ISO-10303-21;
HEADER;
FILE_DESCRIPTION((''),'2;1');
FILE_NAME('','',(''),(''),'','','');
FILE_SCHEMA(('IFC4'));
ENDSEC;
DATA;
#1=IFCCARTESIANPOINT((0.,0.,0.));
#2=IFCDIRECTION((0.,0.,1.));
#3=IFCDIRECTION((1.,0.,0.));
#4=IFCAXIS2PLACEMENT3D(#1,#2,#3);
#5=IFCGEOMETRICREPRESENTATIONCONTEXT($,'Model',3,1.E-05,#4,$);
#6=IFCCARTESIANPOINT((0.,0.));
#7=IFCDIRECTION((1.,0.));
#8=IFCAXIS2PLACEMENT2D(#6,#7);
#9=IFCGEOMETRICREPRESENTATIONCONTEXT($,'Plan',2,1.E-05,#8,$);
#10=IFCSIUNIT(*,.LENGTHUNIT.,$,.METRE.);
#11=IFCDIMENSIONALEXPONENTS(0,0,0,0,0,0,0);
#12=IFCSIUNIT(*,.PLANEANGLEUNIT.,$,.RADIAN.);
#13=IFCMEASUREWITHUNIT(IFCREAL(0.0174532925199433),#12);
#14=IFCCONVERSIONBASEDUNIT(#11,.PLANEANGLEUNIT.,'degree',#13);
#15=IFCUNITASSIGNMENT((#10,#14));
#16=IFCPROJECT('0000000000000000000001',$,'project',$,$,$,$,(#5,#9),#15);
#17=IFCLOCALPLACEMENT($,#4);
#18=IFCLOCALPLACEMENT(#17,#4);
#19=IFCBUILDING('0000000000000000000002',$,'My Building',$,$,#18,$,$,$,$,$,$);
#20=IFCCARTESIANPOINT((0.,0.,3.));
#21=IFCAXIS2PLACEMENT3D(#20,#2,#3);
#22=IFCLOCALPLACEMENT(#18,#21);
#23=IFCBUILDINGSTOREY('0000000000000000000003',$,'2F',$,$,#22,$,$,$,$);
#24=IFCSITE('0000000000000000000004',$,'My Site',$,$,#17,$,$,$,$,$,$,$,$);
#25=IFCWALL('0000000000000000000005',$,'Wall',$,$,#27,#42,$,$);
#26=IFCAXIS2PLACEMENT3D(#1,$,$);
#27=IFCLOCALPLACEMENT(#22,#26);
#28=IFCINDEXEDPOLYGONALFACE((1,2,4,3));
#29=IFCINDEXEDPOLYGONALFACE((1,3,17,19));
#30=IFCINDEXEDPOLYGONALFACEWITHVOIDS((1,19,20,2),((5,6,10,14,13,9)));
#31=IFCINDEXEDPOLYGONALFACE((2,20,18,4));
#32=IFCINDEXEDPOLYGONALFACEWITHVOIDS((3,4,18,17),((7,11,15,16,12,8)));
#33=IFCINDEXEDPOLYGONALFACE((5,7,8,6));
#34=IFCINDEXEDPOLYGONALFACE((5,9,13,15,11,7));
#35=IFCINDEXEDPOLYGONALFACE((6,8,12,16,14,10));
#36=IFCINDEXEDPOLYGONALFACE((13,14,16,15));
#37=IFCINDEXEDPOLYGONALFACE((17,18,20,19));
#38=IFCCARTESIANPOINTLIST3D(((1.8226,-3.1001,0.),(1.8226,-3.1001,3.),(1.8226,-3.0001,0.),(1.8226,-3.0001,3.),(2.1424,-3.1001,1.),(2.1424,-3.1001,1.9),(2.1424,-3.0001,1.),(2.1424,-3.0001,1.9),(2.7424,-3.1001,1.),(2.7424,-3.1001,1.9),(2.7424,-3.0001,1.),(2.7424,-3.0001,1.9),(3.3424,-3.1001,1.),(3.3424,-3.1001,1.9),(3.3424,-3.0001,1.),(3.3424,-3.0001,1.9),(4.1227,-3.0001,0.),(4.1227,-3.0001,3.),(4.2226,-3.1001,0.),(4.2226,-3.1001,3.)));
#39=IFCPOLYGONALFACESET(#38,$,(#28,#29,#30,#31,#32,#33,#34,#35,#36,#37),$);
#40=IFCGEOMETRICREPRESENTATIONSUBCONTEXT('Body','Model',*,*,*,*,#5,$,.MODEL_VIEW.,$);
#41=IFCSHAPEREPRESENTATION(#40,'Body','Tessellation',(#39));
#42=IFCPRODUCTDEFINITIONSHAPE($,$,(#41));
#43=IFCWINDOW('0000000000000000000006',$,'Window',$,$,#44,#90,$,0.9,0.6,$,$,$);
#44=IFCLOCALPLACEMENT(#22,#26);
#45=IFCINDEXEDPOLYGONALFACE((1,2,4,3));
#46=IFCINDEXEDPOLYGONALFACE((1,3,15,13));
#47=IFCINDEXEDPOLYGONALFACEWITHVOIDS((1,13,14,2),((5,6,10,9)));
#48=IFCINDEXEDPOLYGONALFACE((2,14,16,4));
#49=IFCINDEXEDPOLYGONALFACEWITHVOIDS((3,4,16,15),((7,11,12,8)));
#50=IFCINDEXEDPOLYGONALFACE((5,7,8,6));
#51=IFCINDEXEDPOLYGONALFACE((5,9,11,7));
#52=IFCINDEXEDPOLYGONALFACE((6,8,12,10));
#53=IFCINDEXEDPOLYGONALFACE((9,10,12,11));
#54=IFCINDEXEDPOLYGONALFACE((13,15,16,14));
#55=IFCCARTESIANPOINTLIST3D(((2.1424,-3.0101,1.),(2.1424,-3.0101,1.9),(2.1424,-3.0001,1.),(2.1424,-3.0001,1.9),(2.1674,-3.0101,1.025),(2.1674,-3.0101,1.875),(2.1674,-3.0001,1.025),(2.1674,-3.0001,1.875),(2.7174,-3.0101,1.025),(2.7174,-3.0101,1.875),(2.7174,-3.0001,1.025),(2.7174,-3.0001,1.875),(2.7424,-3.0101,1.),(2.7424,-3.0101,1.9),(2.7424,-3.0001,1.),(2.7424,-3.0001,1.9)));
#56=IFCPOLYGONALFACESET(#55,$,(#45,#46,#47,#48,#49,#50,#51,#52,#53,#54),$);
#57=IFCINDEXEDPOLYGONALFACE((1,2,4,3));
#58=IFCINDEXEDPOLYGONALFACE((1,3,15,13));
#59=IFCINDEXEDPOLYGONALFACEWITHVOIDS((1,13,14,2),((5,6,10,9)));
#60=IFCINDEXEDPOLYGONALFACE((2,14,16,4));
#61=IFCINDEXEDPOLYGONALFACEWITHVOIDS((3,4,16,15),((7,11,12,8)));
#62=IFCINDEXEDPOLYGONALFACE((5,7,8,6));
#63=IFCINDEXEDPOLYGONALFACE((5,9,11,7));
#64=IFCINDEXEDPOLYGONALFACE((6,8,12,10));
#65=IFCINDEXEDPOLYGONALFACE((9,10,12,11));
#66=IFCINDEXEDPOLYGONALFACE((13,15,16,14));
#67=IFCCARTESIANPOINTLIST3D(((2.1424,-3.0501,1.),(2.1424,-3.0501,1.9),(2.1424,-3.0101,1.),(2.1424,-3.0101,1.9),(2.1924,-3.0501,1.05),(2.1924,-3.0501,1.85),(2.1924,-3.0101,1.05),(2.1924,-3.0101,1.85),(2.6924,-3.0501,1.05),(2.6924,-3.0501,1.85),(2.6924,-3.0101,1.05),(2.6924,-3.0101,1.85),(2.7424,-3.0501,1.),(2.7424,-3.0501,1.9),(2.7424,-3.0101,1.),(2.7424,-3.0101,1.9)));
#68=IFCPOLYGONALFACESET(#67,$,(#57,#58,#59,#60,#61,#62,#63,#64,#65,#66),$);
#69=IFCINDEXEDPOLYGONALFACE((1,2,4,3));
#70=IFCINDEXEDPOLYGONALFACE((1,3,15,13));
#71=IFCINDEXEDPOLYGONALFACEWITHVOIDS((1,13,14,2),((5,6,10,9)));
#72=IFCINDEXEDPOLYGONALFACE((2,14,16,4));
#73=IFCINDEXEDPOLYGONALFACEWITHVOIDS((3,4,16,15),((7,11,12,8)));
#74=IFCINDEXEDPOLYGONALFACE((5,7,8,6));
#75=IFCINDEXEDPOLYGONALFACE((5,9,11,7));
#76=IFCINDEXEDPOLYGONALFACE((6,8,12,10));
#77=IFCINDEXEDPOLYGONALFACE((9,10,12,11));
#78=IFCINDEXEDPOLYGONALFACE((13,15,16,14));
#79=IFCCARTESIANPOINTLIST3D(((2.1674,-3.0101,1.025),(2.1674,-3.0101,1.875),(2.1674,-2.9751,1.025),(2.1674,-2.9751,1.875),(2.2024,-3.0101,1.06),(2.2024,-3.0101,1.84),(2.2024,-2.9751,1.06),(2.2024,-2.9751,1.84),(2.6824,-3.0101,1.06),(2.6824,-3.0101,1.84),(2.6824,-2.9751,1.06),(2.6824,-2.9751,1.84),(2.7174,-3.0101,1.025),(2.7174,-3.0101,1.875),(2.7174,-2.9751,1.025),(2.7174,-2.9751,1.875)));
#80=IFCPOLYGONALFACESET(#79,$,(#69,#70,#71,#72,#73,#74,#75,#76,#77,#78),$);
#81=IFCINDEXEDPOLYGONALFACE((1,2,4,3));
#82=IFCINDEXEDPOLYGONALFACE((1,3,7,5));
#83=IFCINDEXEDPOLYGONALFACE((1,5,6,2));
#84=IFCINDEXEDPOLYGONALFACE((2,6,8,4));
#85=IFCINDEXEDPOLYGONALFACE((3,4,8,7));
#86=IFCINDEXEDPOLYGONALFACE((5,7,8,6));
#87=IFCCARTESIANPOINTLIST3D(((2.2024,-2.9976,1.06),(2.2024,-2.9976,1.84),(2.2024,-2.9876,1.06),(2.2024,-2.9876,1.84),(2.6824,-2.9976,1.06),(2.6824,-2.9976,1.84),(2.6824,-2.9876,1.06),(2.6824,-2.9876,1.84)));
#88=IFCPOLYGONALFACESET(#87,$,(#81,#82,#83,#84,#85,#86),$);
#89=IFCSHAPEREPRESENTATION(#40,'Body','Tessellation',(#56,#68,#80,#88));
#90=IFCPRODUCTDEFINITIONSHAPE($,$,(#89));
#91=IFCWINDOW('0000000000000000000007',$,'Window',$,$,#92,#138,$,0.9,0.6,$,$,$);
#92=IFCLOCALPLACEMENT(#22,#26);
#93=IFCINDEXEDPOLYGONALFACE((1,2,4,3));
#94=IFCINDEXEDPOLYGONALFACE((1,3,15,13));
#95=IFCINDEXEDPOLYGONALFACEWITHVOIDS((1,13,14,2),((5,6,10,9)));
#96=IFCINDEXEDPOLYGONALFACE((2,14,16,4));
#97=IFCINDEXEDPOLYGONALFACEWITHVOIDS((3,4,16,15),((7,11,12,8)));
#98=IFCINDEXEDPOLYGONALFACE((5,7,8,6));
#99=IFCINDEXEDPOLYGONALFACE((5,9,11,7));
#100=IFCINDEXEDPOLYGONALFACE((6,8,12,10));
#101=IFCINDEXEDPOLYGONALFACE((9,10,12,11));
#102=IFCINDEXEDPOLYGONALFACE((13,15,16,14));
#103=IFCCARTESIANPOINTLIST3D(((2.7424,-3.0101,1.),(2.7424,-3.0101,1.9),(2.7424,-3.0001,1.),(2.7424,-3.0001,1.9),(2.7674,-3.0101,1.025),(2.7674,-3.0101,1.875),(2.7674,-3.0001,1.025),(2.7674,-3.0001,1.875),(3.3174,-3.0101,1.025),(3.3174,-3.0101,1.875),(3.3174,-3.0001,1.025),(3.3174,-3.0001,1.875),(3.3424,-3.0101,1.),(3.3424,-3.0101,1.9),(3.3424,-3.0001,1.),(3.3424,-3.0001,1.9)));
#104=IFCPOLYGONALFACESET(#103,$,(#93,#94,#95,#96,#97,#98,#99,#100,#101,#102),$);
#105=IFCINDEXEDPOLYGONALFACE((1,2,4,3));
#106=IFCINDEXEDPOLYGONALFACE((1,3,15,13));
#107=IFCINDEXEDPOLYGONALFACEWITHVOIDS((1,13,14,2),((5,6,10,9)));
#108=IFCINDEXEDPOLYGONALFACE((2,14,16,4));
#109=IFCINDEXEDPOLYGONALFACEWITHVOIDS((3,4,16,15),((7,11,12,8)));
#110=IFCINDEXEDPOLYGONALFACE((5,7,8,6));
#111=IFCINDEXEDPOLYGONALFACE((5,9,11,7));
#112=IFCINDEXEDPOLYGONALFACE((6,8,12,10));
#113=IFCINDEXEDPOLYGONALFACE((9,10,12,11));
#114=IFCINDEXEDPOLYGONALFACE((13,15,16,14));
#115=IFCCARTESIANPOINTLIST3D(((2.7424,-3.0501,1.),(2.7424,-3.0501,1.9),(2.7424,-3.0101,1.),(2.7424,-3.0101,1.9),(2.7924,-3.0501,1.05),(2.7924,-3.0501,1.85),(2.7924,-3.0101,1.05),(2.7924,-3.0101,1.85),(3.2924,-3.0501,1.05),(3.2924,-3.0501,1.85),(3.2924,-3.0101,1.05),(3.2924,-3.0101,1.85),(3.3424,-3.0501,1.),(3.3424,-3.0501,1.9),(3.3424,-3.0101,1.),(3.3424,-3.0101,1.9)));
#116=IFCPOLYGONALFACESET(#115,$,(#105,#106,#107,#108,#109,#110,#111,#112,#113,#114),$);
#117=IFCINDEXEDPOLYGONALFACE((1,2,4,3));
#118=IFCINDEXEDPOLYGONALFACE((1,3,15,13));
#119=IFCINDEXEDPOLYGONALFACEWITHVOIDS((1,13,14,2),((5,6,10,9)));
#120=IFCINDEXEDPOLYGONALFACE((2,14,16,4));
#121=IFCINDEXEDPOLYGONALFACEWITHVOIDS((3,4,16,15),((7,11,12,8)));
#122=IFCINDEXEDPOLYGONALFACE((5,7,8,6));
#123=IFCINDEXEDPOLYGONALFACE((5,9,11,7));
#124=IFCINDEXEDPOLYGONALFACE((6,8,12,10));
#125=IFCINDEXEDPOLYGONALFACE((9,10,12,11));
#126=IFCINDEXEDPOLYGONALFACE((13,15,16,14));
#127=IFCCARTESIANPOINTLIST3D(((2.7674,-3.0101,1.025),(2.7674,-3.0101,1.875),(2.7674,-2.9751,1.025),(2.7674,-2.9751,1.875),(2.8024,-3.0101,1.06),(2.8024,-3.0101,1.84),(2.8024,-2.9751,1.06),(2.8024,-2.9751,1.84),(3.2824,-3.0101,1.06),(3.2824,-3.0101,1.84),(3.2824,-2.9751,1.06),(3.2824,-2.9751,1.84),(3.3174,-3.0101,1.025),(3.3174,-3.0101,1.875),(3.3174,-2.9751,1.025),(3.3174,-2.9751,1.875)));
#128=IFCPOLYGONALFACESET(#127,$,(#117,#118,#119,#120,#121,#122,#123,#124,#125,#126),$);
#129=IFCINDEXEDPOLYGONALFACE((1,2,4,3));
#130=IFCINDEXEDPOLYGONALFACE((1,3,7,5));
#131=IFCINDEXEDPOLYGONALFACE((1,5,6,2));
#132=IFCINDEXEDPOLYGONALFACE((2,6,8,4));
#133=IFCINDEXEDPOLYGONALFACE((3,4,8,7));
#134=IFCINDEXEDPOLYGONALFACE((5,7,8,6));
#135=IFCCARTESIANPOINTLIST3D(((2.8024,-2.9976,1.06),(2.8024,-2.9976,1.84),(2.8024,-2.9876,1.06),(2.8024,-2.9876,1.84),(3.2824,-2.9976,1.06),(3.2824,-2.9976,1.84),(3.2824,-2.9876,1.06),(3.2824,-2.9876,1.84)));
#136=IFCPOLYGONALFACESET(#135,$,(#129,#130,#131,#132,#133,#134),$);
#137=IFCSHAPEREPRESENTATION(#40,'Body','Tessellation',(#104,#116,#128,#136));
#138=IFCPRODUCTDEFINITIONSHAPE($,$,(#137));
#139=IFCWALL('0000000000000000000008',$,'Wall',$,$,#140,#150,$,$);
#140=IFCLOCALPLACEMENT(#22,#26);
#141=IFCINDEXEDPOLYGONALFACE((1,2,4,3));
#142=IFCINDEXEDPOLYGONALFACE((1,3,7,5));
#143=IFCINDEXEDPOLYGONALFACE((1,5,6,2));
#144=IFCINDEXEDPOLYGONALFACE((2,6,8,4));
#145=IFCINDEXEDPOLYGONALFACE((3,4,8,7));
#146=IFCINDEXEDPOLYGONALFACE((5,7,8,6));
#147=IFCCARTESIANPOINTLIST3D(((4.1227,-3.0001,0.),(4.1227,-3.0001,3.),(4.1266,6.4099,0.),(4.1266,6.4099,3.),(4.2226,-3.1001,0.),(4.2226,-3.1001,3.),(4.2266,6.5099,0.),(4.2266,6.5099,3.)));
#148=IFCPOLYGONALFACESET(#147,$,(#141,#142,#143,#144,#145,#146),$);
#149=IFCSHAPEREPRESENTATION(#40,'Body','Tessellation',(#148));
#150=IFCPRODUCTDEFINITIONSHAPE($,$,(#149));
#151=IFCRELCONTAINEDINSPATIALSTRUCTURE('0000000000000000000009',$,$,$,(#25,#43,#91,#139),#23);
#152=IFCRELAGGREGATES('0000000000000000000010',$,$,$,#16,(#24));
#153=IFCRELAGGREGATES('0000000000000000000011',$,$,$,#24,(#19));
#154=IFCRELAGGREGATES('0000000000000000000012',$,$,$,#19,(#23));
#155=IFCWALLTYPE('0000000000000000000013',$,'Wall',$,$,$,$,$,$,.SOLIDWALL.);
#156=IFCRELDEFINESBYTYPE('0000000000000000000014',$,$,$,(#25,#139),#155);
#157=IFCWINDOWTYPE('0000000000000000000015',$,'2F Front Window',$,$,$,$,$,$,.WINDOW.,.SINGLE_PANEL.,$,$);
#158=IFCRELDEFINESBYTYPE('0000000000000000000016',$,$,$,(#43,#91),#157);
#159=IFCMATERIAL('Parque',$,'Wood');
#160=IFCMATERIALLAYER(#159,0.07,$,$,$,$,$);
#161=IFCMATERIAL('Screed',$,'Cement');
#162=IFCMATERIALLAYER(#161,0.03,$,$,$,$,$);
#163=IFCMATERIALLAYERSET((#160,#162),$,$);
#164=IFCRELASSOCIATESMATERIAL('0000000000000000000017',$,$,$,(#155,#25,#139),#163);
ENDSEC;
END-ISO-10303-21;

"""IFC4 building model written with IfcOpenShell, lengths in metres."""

from ifc_helpers import new_model, entity, si_unit, converted_unit, frame, origin_with_axes, origin_2d_with_axis, place, context, subcontext, project, spatial, line, indexed_curve, outline, extrude, shape, source, transform, mapped, material, layer, layer_set, layer_usage, type_object, type_shapes, element, fill, save


model = new_model("IFC4")

# Units and contexts
model_context = context("Model", 3, precision=1e-05, world=origin_with_axes())
plan_context = context("Plan", 2, precision=1e-05, world=origin_2d_with_axis())
body_context_1 = subcontext(model_context, "Body", "Model", "MODEL_VIEW")
body_context_2 = subcontext(plan_context, "Body", "Plan", "PLAN_VIEW")
ifc_project = project(units=[si_unit("LENGTHUNIT", "METRE"), converted_unit("PLANEANGLEUNIT", "degree", entity("IfcReal", 0.0174532925199433), si_unit("PLANEANGLEUNIT", "RADIAN"), dimensions=[0, 0, 0, 0, 0, 0, 0])], contexts=[model_context, plan_context])

# Site, building, storey
site_placement = place(None, origin_with_axes())
site = spatial("IfcSite", under=ifc_project, at=site_placement, Name="My Site")
building_placement = place(site_placement, origin_with_axes())
building = spatial("IfcBuilding", under=site, at=building_placement, Name="My Building")
storey_placement = place(building_placement, frame((0.0, 0.0, 3.0), z_axis=(0.0, 0.0, 1.0), x_axis=(1.0, 0.0, 0.0)))
storey = spatial("IfcBuildingStorey", under=building, at=storey_placement, Name="2F")

# Wall, openings, windows
ifc_material_1 = material(Name="Parque", Category="Wood")
ifc_layer_1 = layer(ifc_material_1, 0.07)
ifc_material_2 = material(Name="Screed", Category="Cement")
ifc_layer_2 = layer(ifc_material_2, 0.03)
ifc_layer_set_1 = layer_set([ifc_layer_1, ifc_layer_2])
ifc_layer_usage_1 = layer_usage(ifc_layer_set_1, "AXIS2", "POSITIVE", 0.0)
wall_type = type_object("IfcWallType", Name="Wall", PredefinedType="SOLIDWALL", material=ifc_layer_set_1)
wall_1_placement = place(storey_placement, frame((1.8226, -3.1001, 0.0), z_axis=(0.0, 0.0, 1.0), x_axis=(1.0, 0.0, 0.0)))
wall_1 = element("IfcWall", 1, at=wall_1_placement, inside=storey, type_object=wall_type, material=ifc_layer_usage_1, Name="Wall", context=body_context_1, shape_type="SweptSolid", body=[
    extrude(outline(indexed_curve([(0.0, 0.0), (0.0, 0.1), (2.3, 0.1), (2.4, 0.0)], segments=[line(1, 2, 3, 4, 1)])), origin_with_axes(), (0.0, 0.0, 1.0), 3.0),
])
shared_shape_1 = source(origin_with_axes(), body_context_1, "Body", "SweptSolid", [
    extrude(outline(indexed_curve([(0.0, 0.0), (0.6, 0.0), (0.6, 0.9), (0.0, 0.9)], segments=[line(1, 2, 3, 4, 1)])), frame((0.0, -0.6, 0.0), z_axis=(0.0, -1.0, 0.0), x_axis=(1.0, 0.0, 0.0)), (0.0, 0.0, -1.0), 1.2),
])
opening_1_placement = place(wall_1_placement, frame((0.3197, 0.0, 1.0), z_axis=(0.0, 0.0, 1.0), x_axis=(1.0, 0.0, 0.0)))
opening_1 = element("IfcOpeningElement", 2, at=opening_1_placement, cuts=wall_1, PredefinedType="OPENING", context=body_context_1, shape_type="MappedRepresentation", body=[
    mapped(shared_shape_1, transform((0.0, 0.0, 0.0), x_axis=(1.0, 0.0, 0.0), y_axis=(0.0, 1.0, 0.0), z_axis=(0.0, 0.0, 1.0), scale=1.0)),
])
opening_2_placement = place(wall_1_placement, frame((0.9197, 0.0, 1.0), z_axis=(0.0, 0.0, 1.0), x_axis=(1.0, 0.0, 0.0)))
opening_2 = element("IfcOpeningElement", 3, at=opening_2_placement, cuts=wall_1, PredefinedType="OPENING", context=body_context_1, shape_type="MappedRepresentation", body=[
    mapped(shared_shape_1, transform((0.0, 0.0, 0.0), x_axis=(1.0, 0.0, 0.0), y_axis=(0.0, 1.0, 0.0), z_axis=(0.0, 0.0, 1.0), scale=1.0)),
])
window_type = type_object("IfcWindowType", Name="2F Front Window", PartitioningType="SINGLE_PANEL", PredefinedType="WINDOW")
shared_shape_2 = source(origin_with_axes(), body_context_1, "Body", "SweptSolid", [
    extrude(outline(indexed_curve([(0.0, 0.0), (0.6, 0.0), (0.6, 0.9), (0.0, 0.9)], segments=[line(1, 2, 3, 4, 1)]), holes=[indexed_curve([(0.025, 0.025), (0.575, 0.025), (0.575, 0.875), (0.025, 0.875)], segments=[line(1, 2, 3, 4, 1)])]), frame((0.0, 0.09, 0.0), z_axis=(0.0, -1.0, 0.0), x_axis=(1.0, 0.0, 0.0)), (0.0, 0.0, -1.0), 0.01),
    extrude(outline(indexed_curve([(0.0, 0.0), (0.6, 0.0), (0.6, 0.9), (0.0, 0.9)], segments=[line(1, 2, 3, 4, 1)]), holes=[indexed_curve([(0.05, 0.05), (0.55, 0.05), (0.55, 0.85), (0.05, 0.85)], segments=[line(1, 2, 3, 4, 1)])]), frame((0.0, 0.05, 0.0), z_axis=(0.0, -1.0, 0.0), x_axis=(1.0, 0.0, 0.0)), (0.0, 0.0, -1.0), 0.04),
    extrude(outline(indexed_curve([(0.0, 0.0), (0.55, 0.0), (0.55, 0.85), (0.0, 0.85)], segments=[line(1, 2, 3, 4, 1)]), holes=[indexed_curve([(0.035, 0.035), (0.515, 0.035), (0.515, 0.815), (0.035, 0.815)], segments=[line(1, 2, 3, 4, 1)])]), frame((0.025, 0.09, 0.025), z_axis=(0.0, -1.0, 0.0), x_axis=(1.0, 0.0, 0.0)), (0.0, 0.0, -1.0), 0.035),
    extrude(outline(indexed_curve([(0.035, 0.035), (0.515, 0.035), (0.515, 0.815), (0.035, 0.815)], segments=[line(1, 2, 3, 4, 1)])), frame((0.025, 0.1025, 0.025), z_axis=(0.0, -1.0, 0.0), x_axis=(1.0, 0.0, 0.0)), (0.0, 0.0, -1.0), 0.01),
])
shared_shape_3 = source(origin_with_axes(), body_context_2, "Body", "Curve2D", [
    entity("IfcIndexedPolyCurve", entity("IfcCartesianPointList2D", [[0.05, 0.05], [0.55, 0.05]])),
    entity("IfcIndexedPolyCurve", entity("IfcCartesianPointList2D", [[0.0, 0.1], [0.025, 0.1], [0.025, 0.09], [0.05, 0.09], [0.05, 0.05], [0.0, 0.05]]), [entity("IfcLineIndex", [1, 2, 3, 4, 5, 6, 1])]),
    entity("IfcIndexedPolyCurve", entity("IfcCartesianPointList2D", [[0.6, 0.1], [0.575, 0.1], [0.575, 0.09], [0.55, 0.09], [0.55, 0.05], [0.6, 0.05]]), [entity("IfcLineIndex", [1, 2, 3, 4, 5, 6, 1])]),
    entity("IfcIndexedPolyCurve", entity("IfcCartesianPointList2D", [[0.025, 0.09], [0.06, 0.09], [0.06, 0.125], [0.025, 0.125]]), [entity("IfcLineIndex", [1, 2, 3, 4, 1])]),
    entity("IfcIndexedPolyCurve", entity("IfcCartesianPointList2D", [[0.575, 0.09], [0.54, 0.09], [0.54, 0.125], [0.575, 0.125]]), [entity("IfcLineIndex", [1, 2, 3, 4, 1])]),
    entity("IfcIndexedPolyCurve", entity("IfcCartesianPointList2D", [[0.06, 0.09], [0.54, 0.09]])),
    entity("IfcIndexedPolyCurve", entity("IfcCartesianPointList2D", [[0.06, 0.125], [0.54, 0.125]])),
    entity("IfcIndexedPolyCurve", entity("IfcCartesianPointList2D", [[0.06, 0.1075], [0.54, 0.1075]])),
])
type_shapes(window_type, [shared_shape_2, shared_shape_3])
window_1_placement = place(opening_1_placement, origin_with_axes())
window_1 = element("IfcWindow", 4, at=window_1_placement, inside=storey, type_object=window_type, Name="Window", OverallHeight=0.9, OverallWidth=0.6, shapes=[
    shape(body_context_1, "Body", "MappedRepresentation", [mapped(shared_shape_2, transform((0.0, 0.0, 0.0), x_axis=(1.0, 0.0, 0.0), y_axis=(0.0, 1.0, 0.0), z_axis=(0.0, 0.0, 1.0), scale=1.0))]),
    shape(body_context_2, "Body", "MappedRepresentation", [mapped(shared_shape_3, transform((0.0, 0.0, 0.0), x_axis=(1.0, 0.0, 0.0), y_axis=(0.0, 1.0, 0.0), z_axis=(0.0, 0.0, 1.0), scale=1.0))]),
])
fill(opening_1, window_1)
window_2_placement = place(opening_2_placement, origin_with_axes())
window_2 = element("IfcWindow", 5, at=window_2_placement, inside=storey, type_object=window_type, Name="Window", OverallHeight=0.9, OverallWidth=0.6, shapes=[
    shape(body_context_1, "Body", "MappedRepresentation", [mapped(shared_shape_2, transform((0.0, 0.0, 0.0), x_axis=(1.0, 0.0, 0.0), y_axis=(0.0, 1.0, 0.0), z_axis=(0.0, 0.0, 1.0), scale=1.0))]),
    shape(body_context_2, "Body", "MappedRepresentation", [mapped(shared_shape_3, transform((0.0, 0.0, 0.0), x_axis=(1.0, 0.0, 0.0), y_axis=(0.0, 1.0, 0.0), z_axis=(0.0, 0.0, 1.0), scale=1.0))]),
])
fill(opening_2, window_2)

# Wall
ifc_layer_usage_2 = layer_usage(ifc_layer_set_1, "AXIS2", "POSITIVE", 0.0)
wall_2_placement = place(storey_placement, frame((4.2226, -3.1001, 0.0), z_axis=(0.0, 0.0, 1.0), x_axis=(0.000415, 1.0, 0.0)))
element("IfcWall", 6, at=wall_2_placement, inside=storey, type_object=wall_type, material=ifc_layer_usage_2, Name="Wall", context=body_context_1, shape_type="SweptSolid", body=[
    extrude(outline(indexed_curve([(0.0, 0.0), (0.1, 0.1), (9.51, 0.1), (9.61, 0.0)], segments=[line(1, 2, 3, 4, 1)])), origin_with_axes(), (0.0, 0.0, 1.0), 3.0),
])

save(model, "model.ifc")
